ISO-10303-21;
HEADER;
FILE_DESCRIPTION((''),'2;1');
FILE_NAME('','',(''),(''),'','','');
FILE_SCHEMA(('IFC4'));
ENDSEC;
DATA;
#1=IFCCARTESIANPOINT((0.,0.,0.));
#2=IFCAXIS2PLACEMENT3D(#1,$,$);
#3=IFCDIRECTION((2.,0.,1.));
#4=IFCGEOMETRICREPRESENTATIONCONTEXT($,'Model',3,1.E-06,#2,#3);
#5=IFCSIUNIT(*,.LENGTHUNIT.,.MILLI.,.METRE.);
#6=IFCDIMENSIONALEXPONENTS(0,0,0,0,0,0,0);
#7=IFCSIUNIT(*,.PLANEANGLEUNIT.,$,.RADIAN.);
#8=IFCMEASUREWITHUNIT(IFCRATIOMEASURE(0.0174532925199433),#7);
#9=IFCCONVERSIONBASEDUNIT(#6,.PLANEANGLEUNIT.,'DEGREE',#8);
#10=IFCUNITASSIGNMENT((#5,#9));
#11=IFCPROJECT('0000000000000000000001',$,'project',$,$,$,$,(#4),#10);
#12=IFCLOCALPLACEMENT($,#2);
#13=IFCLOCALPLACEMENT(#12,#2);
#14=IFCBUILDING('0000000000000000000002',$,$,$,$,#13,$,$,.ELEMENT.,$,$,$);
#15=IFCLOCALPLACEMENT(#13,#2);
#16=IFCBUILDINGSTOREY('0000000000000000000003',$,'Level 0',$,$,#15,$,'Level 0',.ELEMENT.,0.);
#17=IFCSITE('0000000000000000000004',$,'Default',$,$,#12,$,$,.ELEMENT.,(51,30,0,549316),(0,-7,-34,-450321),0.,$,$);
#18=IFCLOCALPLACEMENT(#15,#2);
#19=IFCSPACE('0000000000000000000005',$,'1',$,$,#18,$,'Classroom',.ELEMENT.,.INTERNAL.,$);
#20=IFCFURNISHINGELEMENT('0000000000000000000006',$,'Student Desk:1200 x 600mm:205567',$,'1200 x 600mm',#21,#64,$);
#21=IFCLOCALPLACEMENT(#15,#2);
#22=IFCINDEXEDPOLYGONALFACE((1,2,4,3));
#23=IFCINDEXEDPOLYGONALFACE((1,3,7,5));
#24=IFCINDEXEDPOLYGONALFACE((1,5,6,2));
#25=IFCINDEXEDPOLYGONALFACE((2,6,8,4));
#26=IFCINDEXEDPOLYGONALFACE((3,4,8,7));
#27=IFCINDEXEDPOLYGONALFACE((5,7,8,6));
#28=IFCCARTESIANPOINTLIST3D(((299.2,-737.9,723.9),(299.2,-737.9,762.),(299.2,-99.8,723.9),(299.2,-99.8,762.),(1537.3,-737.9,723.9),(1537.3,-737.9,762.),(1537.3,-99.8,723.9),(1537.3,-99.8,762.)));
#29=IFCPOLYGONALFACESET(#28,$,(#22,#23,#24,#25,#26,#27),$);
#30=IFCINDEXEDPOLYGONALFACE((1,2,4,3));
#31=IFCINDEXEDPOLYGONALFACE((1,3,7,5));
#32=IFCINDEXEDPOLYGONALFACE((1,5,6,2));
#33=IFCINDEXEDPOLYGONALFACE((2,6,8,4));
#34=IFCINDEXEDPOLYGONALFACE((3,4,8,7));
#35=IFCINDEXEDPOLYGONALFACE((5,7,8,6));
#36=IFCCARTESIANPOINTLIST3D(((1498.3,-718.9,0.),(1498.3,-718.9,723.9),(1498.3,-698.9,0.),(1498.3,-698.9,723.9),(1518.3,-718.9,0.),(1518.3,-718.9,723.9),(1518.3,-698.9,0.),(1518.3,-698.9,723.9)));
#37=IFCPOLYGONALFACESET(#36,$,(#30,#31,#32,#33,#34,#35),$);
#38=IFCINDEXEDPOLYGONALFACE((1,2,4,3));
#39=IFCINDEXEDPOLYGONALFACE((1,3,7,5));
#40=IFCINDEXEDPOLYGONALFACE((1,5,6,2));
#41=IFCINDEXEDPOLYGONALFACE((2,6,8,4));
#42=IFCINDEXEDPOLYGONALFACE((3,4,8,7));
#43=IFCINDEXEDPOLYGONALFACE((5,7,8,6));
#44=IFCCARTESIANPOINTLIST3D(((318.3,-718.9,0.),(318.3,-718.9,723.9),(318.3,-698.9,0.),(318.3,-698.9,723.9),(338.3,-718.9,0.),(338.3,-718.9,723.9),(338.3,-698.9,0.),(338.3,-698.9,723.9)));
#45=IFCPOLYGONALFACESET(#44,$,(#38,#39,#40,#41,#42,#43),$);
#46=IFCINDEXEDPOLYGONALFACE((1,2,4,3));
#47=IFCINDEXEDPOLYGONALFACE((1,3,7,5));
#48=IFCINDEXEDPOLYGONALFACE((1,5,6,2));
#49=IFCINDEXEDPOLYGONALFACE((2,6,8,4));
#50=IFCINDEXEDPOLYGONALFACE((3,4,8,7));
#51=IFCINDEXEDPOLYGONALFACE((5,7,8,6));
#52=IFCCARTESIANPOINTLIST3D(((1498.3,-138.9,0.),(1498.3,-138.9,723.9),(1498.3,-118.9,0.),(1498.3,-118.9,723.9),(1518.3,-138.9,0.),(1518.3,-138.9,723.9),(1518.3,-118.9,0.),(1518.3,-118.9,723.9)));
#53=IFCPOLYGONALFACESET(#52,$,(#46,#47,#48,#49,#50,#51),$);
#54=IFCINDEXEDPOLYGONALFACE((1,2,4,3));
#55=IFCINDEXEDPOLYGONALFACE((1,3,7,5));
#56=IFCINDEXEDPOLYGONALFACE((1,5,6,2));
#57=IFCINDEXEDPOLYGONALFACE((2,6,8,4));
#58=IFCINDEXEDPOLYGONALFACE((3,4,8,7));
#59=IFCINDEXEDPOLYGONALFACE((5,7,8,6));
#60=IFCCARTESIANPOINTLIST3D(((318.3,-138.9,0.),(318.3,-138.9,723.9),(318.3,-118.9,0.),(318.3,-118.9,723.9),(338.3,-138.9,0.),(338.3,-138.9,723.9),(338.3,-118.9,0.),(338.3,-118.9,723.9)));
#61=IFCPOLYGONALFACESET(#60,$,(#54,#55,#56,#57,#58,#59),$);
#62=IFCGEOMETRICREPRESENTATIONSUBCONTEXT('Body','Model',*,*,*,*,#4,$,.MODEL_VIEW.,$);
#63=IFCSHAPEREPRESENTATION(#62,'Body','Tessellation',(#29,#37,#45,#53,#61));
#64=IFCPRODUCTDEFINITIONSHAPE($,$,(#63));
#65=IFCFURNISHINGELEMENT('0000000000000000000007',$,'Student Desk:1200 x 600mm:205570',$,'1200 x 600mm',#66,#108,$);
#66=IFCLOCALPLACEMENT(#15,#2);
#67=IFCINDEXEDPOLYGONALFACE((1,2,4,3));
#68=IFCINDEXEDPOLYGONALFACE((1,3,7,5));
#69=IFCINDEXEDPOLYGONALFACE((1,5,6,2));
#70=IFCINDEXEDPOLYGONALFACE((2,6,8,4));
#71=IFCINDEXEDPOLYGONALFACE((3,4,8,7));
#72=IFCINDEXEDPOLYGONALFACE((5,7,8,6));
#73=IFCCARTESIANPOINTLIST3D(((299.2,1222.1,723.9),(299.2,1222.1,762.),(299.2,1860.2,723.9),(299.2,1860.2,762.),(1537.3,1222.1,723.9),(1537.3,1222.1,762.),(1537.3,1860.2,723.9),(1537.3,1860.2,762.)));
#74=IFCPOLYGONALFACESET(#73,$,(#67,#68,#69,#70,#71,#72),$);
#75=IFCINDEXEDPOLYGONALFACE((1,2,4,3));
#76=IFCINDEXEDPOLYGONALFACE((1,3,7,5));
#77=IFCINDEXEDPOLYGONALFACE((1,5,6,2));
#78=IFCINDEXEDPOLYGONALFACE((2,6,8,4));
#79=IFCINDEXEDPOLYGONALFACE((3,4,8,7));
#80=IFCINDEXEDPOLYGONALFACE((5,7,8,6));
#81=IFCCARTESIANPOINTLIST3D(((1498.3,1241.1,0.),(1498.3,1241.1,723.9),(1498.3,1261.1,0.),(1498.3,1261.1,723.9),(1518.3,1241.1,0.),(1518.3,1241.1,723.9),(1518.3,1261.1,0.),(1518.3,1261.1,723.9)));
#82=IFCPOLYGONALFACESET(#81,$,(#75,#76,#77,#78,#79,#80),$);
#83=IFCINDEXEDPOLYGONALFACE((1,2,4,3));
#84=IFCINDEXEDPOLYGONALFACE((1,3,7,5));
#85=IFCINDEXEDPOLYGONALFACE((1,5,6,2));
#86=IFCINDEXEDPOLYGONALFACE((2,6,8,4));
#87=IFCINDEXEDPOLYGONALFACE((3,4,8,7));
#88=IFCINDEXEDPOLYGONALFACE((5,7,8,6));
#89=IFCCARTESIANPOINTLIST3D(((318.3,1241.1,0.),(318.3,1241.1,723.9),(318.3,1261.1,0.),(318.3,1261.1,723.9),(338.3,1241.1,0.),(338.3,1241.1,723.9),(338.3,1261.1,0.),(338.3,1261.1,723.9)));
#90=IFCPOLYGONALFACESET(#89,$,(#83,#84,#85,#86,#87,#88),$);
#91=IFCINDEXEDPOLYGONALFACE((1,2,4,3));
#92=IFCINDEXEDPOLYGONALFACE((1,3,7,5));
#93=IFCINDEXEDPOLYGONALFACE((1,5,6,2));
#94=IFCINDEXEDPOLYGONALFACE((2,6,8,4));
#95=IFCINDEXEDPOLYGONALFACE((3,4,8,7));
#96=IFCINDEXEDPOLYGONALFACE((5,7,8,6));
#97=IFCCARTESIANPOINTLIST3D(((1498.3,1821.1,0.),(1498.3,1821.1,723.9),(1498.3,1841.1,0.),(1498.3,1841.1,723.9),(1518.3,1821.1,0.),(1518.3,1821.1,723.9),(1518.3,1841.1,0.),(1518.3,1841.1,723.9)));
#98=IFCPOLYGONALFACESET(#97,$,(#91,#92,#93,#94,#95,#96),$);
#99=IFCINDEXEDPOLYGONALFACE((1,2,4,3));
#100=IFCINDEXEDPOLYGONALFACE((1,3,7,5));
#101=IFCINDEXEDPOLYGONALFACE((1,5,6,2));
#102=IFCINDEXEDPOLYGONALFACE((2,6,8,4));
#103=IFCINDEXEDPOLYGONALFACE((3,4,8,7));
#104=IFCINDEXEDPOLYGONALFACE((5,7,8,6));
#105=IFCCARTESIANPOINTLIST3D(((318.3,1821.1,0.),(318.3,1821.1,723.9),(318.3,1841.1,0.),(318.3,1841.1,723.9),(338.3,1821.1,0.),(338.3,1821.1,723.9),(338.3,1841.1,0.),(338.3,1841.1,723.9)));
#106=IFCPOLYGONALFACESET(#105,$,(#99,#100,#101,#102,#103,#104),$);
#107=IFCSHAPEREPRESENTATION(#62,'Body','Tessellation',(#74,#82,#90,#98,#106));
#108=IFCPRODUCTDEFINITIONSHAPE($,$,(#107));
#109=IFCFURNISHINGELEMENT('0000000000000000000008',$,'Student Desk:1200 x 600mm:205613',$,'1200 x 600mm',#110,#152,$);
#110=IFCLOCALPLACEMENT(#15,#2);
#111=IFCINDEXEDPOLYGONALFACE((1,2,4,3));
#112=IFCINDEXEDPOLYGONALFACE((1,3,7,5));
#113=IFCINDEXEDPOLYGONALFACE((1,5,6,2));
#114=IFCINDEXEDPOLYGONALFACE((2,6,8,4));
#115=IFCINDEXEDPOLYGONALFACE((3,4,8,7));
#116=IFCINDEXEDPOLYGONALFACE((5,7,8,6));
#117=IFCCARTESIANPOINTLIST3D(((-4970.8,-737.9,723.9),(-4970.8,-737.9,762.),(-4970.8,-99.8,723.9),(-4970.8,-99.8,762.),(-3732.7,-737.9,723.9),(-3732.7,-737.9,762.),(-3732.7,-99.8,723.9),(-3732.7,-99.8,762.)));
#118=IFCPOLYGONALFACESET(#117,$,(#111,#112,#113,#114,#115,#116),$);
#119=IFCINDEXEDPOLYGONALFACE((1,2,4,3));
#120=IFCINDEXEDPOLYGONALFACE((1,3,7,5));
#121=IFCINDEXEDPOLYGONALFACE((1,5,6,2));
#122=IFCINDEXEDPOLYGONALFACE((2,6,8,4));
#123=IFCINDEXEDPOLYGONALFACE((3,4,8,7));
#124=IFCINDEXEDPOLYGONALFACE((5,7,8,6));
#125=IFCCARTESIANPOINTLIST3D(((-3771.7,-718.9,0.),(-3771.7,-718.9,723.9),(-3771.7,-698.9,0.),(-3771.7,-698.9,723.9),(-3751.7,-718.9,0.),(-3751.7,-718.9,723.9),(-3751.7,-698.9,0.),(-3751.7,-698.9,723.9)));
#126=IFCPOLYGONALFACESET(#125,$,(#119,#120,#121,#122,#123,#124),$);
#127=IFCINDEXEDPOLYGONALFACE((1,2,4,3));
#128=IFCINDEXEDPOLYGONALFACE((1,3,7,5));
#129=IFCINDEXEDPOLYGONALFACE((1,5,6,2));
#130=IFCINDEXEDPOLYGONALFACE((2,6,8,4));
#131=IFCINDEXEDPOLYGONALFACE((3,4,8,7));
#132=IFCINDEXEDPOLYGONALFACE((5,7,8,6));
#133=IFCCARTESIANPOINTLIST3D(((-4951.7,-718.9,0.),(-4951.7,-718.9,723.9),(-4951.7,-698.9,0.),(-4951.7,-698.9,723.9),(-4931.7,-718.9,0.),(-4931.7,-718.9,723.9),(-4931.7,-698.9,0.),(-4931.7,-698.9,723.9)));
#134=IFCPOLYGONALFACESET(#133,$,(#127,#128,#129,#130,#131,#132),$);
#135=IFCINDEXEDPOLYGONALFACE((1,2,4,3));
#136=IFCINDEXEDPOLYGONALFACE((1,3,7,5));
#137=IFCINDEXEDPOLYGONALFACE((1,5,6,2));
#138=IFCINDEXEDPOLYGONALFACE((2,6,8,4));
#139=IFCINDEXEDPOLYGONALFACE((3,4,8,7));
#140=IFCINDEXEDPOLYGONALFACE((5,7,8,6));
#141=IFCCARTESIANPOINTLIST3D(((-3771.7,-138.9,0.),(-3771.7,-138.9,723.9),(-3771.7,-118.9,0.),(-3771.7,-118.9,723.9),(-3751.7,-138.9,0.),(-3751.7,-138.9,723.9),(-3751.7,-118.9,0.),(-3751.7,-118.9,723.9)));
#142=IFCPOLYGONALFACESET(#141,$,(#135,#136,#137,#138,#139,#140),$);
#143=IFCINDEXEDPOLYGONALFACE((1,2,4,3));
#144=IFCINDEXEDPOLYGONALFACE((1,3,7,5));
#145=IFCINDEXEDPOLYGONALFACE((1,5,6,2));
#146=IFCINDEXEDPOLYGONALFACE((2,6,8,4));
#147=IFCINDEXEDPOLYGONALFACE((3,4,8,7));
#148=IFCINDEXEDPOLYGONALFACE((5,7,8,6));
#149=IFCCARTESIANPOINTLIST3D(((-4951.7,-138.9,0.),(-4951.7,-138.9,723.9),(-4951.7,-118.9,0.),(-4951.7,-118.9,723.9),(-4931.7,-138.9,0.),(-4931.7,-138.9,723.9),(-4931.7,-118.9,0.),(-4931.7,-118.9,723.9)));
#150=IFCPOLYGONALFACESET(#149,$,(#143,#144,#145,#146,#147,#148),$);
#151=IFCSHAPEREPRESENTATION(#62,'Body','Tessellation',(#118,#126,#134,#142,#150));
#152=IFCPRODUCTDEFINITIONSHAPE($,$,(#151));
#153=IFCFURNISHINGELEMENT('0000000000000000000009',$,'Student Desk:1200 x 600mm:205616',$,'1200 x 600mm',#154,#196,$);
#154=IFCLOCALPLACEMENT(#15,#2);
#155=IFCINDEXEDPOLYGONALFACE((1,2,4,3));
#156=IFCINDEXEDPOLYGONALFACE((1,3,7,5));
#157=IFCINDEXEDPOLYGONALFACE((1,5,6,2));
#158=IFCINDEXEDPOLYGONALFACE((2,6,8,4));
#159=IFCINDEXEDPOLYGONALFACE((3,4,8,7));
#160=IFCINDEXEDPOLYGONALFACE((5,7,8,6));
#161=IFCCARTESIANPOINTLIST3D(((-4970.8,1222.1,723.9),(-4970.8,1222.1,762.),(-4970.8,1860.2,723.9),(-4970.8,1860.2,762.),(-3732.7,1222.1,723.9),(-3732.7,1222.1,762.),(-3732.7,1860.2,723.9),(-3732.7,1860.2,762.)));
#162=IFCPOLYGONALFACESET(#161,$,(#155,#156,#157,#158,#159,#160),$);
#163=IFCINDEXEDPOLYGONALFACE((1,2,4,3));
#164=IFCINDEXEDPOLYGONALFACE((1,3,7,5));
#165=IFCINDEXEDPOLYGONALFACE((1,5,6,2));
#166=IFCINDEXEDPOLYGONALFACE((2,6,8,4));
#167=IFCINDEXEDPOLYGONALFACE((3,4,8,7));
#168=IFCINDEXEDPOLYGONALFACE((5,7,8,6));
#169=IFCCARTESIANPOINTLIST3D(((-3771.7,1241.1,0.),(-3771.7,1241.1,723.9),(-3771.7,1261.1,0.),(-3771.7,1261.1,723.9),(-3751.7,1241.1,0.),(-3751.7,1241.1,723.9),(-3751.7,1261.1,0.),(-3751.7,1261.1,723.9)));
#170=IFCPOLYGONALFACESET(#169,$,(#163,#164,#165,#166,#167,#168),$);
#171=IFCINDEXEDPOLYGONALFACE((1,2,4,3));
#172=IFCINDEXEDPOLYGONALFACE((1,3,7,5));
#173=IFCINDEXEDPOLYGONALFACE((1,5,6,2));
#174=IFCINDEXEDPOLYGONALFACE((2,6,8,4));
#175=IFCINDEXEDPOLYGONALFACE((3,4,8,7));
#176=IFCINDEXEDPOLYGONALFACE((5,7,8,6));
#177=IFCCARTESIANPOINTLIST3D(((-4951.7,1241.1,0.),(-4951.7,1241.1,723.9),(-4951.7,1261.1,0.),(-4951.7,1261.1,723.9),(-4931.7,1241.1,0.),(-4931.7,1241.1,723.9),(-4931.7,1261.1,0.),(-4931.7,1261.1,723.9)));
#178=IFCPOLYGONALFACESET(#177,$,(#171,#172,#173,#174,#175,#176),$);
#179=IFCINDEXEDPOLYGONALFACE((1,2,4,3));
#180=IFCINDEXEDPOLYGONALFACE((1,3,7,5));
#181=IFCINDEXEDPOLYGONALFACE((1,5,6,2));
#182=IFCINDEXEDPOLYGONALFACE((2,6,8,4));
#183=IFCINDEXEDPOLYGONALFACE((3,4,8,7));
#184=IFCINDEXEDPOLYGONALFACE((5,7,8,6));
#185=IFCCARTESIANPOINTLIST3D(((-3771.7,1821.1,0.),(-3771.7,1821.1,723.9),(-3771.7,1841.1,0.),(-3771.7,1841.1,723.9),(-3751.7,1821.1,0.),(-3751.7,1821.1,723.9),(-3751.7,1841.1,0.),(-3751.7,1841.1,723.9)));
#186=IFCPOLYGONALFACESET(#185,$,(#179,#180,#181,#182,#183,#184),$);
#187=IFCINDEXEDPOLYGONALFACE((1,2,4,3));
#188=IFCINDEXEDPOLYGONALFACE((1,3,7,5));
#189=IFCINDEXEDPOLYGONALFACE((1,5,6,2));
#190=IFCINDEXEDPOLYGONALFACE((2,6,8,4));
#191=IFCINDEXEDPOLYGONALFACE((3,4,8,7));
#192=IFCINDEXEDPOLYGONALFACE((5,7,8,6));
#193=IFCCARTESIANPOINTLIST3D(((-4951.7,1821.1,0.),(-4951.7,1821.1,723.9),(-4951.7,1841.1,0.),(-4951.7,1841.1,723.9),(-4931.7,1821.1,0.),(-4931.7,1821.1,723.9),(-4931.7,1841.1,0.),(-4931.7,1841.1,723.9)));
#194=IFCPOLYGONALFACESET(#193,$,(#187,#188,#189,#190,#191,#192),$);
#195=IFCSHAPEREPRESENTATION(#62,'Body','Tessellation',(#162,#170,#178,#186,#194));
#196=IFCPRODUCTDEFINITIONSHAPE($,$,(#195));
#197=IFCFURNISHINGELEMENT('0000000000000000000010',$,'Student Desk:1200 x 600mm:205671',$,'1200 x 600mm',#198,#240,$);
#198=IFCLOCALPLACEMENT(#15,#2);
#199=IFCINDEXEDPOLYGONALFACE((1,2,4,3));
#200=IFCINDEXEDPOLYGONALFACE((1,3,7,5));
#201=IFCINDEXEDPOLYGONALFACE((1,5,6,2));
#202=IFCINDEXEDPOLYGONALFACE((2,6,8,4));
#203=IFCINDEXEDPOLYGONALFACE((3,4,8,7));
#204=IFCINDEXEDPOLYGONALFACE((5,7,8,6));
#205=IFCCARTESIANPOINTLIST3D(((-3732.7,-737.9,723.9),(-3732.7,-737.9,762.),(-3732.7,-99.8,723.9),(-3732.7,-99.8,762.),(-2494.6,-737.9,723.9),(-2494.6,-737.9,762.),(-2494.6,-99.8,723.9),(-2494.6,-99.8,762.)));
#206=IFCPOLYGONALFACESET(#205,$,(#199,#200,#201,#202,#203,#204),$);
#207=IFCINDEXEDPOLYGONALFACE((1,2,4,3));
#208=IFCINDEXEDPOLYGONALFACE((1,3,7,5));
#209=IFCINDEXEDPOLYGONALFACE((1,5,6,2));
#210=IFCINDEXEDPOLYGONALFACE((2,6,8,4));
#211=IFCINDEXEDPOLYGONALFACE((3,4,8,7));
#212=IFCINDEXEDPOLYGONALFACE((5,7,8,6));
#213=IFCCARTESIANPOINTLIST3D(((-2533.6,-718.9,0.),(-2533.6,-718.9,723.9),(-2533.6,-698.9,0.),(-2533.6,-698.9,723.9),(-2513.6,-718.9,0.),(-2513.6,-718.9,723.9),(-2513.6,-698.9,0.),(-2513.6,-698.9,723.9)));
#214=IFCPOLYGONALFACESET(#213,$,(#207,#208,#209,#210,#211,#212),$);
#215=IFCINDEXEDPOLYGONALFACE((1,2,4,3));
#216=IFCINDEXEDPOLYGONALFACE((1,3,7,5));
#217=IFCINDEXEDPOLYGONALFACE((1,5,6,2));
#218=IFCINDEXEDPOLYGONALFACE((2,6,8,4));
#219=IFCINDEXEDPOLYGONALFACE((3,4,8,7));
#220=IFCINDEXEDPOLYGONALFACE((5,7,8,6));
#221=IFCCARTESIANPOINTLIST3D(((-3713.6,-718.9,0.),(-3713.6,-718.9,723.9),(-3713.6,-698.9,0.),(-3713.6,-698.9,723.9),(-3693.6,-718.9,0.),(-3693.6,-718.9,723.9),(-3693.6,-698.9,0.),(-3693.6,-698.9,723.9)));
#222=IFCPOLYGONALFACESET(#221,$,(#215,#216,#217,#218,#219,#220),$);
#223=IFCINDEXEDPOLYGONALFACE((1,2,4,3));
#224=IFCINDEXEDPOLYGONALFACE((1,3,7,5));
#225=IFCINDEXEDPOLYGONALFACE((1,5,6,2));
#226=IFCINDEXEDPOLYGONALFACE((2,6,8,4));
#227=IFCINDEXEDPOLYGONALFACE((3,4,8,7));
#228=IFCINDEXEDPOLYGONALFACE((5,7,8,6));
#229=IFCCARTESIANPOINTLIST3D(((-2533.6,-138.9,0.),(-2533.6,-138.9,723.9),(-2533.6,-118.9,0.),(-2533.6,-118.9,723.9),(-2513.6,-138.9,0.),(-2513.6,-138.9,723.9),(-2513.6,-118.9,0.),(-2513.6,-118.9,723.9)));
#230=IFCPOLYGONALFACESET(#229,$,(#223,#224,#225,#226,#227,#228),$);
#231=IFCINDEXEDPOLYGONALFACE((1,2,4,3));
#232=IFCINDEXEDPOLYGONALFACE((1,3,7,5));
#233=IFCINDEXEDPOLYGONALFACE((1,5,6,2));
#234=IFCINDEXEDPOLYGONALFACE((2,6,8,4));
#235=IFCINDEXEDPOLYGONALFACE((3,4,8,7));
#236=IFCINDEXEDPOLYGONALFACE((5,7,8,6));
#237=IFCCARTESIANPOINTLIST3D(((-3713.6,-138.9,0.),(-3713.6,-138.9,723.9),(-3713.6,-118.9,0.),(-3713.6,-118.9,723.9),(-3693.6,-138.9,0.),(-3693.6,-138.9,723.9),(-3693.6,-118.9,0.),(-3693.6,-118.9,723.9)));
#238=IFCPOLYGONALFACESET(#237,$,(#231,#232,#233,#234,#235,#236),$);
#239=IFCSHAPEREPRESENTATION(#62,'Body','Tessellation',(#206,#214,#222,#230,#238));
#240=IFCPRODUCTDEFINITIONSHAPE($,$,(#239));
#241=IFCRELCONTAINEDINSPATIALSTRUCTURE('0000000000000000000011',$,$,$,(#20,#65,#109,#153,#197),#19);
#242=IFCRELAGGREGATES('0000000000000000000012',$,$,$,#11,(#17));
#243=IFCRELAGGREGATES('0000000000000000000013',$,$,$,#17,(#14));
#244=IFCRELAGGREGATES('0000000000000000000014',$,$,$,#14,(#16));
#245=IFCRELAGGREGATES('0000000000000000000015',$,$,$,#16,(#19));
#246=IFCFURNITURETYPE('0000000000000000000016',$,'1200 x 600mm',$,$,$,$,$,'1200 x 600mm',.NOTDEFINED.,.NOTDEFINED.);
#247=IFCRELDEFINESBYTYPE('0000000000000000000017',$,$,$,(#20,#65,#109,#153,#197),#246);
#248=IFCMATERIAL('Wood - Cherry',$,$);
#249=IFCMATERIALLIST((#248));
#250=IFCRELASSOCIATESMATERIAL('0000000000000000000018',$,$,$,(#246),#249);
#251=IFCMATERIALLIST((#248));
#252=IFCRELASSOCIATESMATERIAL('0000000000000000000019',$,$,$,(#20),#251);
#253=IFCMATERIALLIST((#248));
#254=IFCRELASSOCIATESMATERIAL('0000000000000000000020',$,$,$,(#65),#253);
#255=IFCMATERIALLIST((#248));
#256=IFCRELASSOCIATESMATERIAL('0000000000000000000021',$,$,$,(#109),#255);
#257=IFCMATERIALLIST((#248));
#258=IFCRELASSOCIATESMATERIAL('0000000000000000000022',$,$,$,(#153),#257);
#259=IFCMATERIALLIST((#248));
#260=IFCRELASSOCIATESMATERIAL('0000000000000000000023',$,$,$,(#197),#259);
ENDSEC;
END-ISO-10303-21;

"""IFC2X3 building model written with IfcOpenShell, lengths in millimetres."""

from ifc_helpers import new_model, entity, si_unit, converted_unit, direction, frame, frame_2d, origin, origin_2d_with_axis, place, context, subcontext, project, spatial, rectangle, extrude, source, transform, mapped, material, material_list, type_object, type_shapes, element, save


model = new_model("IFC2X3")

# Units and contexts
model_context = context("Model", 3, precision=1e-06, world=origin(), true_north=direction((2.0, 0.0, 1.0)))
body_context = subcontext(model_context, "Body", "Model", "MODEL_VIEW")
ifc_project = project(units=[si_unit("LENGTHUNIT", "METRE", prefix="MILLI"), converted_unit("PLANEANGLEUNIT", "DEGREE", entity("IfcRatioMeasure", 0.0174532925199433), si_unit("PLANEANGLEUNIT", "RADIAN"), dimensions=[0, 0, 0, 0, 0, 0, 0])], contexts=[model_context])

# Site, building, storey
site_placement = place(None, origin())
site = spatial("IfcSite", under=ifc_project, at=site_placement, Name="Default", CompositionType="ELEMENT", RefLatitude=(51, 30, 0, 549316), RefLongitude=(0, -7, -34, -450321), RefElevation=0.0)
building_placement = place(site_placement, origin())
building = spatial("IfcBuilding", under=site, at=building_placement, CompositionType="ELEMENT")
storey_placement = place(building_placement, origin())
storey = spatial("IfcBuildingStorey", under=building, at=storey_placement, Name="Level 0", LongName="Level 0", CompositionType="ELEMENT", Elevation=0.0)

# Shared definitions
space_placement = place(storey_placement, origin())
space = spatial("IfcSpace", under=storey, at=space_placement, Name="1", LongName="Classroom", CompositionType="ELEMENT", InteriorOrExteriorSpace="INTERNAL")

# Furnishing elements
ifc_material_1 = material(Name="Wood - Cherry")
ifc_material_list_1 = material_list([ifc_material_1])
furniture_type = type_object("IfcFurnitureType", Name="1200 x 600mm", ElementType="1200 x 600mm", AssemblyPlace="NOTDEFINED", material=ifc_material_list_1)
shared_shape_1 = source(origin(), body_context, "Body", "SweptSolid", [
    extrude(rectangle(XDim=1238.1, YDim=638.1, at=origin_2d_with_axis()), frame((600.0, 300.0, 723.9), z_axis=(0.0, 0.0, 1.0), x_axis=(-1.0, 0.0, 0.0)), (0.0, 0.0, 1.0), 38.1),
    extrude(rectangle(XDim=20.0, YDim=20.0, at=origin_2d_with_axis()), frame((1190.0, 10.0, 0.0)), (0.0, 0.0, 1.0), 723.9),
    extrude(rectangle(XDim=20.0, YDim=20.0, at=frame_2d((0.0, 0.0), x_axis=(1.0, 0.0))), frame((10.0, 10.0, 0.0), z_axis=(0.0, 0.0, 1.0), x_axis=(0.0, 1.0, 0.0)), (0.0, 0.0, 1.0), 723.9),
    extrude(rectangle(XDim=20.0, YDim=20.0, at=frame_2d((0.0, 0.0), x_axis=(1.0, 0.0))), frame((1190.0, 590.0, 0.0), z_axis=(0.0, 0.0, 1.0), x_axis=(0.0, -1.0, 0.0)), (0.0, 0.0, 1.0), 723.9),
    extrude(rectangle(XDim=20.0, YDim=20.0, at=origin_2d_with_axis()), frame((10.0, 590.0, 0.0), z_axis=(0.0, 0.0, 1.0), x_axis=(-1.0, 0.0, 0.0)), (0.0, 0.0, 1.0), 723.9),
])
type_shapes(furniture_type, [shared_shape_1])
ifc_material_list_2 = material_list([ifc_material_1])
furnishing_1_placement = place(space_placement, frame((318.3, -718.9, 0.0)))
element("IfcFurnishingElement", 1, at=furnishing_1_placement, inside=space, type_object=furniture_type, material=ifc_material_list_2, Name="Student Desk:1200 x 600mm:205567", ObjectType="1200 x 600mm", context=body_context, shape_type="MappedRepresentation", body=[
    mapped(shared_shape_1, transform((0.0, 0.0, 0.0), scale=1.0)),
])
ifc_material_list_3 = material_list([ifc_material_1])
furnishing_2_placement = place(space_placement, frame((318.3, 1241.1, 0.0)))
element("IfcFurnishingElement", 2, at=furnishing_2_placement, inside=space, type_object=furniture_type, material=ifc_material_list_3, Name="Student Desk:1200 x 600mm:205570", ObjectType="1200 x 600mm", context=body_context, shape_type="MappedRepresentation", body=[
    mapped(shared_shape_1, transform((0.0, 0.0, 0.0), scale=1.0)),
])
ifc_material_list_4 = material_list([ifc_material_1])
furnishing_3_placement = place(space_placement, frame((-4951.7, -718.9, 0.0)))
element("IfcFurnishingElement", 3, at=furnishing_3_placement, inside=space, type_object=furniture_type, material=ifc_material_list_4, Name="Student Desk:1200 x 600mm:205613", ObjectType="1200 x 600mm", context=body_context, shape_type="MappedRepresentation", body=[
    mapped(shared_shape_1, transform((0.0, 0.0, 0.0), scale=1.0)),
])
ifc_material_list_5 = material_list([ifc_material_1])
furnishing_4_placement = place(space_placement, frame((-4951.7, 1241.1, 0.0)))
element("IfcFurnishingElement", 4, at=furnishing_4_placement, inside=space, type_object=furniture_type, material=ifc_material_list_5, Name="Student Desk:1200 x 600mm:205616", ObjectType="1200 x 600mm", context=body_context, shape_type="MappedRepresentation", body=[
    mapped(shared_shape_1, transform((0.0, 0.0, 0.0), scale=1.0)),
])
ifc_material_list_6 = material_list([ifc_material_1])
furnishing_5_placement = place(space_placement, frame((-3713.6, -718.9, 0.0)))
element("IfcFurnishingElement", 5, at=furnishing_5_placement, inside=space, type_object=furniture_type, material=ifc_material_list_6, Name="Student Desk:1200 x 600mm:205671", ObjectType="1200 x 600mm", context=body_context, shape_type="MappedRepresentation", body=[
    mapped(shared_shape_1, transform((0.0, 0.0, 0.0), scale=1.0)),
])

save(model, "model.ifc")
